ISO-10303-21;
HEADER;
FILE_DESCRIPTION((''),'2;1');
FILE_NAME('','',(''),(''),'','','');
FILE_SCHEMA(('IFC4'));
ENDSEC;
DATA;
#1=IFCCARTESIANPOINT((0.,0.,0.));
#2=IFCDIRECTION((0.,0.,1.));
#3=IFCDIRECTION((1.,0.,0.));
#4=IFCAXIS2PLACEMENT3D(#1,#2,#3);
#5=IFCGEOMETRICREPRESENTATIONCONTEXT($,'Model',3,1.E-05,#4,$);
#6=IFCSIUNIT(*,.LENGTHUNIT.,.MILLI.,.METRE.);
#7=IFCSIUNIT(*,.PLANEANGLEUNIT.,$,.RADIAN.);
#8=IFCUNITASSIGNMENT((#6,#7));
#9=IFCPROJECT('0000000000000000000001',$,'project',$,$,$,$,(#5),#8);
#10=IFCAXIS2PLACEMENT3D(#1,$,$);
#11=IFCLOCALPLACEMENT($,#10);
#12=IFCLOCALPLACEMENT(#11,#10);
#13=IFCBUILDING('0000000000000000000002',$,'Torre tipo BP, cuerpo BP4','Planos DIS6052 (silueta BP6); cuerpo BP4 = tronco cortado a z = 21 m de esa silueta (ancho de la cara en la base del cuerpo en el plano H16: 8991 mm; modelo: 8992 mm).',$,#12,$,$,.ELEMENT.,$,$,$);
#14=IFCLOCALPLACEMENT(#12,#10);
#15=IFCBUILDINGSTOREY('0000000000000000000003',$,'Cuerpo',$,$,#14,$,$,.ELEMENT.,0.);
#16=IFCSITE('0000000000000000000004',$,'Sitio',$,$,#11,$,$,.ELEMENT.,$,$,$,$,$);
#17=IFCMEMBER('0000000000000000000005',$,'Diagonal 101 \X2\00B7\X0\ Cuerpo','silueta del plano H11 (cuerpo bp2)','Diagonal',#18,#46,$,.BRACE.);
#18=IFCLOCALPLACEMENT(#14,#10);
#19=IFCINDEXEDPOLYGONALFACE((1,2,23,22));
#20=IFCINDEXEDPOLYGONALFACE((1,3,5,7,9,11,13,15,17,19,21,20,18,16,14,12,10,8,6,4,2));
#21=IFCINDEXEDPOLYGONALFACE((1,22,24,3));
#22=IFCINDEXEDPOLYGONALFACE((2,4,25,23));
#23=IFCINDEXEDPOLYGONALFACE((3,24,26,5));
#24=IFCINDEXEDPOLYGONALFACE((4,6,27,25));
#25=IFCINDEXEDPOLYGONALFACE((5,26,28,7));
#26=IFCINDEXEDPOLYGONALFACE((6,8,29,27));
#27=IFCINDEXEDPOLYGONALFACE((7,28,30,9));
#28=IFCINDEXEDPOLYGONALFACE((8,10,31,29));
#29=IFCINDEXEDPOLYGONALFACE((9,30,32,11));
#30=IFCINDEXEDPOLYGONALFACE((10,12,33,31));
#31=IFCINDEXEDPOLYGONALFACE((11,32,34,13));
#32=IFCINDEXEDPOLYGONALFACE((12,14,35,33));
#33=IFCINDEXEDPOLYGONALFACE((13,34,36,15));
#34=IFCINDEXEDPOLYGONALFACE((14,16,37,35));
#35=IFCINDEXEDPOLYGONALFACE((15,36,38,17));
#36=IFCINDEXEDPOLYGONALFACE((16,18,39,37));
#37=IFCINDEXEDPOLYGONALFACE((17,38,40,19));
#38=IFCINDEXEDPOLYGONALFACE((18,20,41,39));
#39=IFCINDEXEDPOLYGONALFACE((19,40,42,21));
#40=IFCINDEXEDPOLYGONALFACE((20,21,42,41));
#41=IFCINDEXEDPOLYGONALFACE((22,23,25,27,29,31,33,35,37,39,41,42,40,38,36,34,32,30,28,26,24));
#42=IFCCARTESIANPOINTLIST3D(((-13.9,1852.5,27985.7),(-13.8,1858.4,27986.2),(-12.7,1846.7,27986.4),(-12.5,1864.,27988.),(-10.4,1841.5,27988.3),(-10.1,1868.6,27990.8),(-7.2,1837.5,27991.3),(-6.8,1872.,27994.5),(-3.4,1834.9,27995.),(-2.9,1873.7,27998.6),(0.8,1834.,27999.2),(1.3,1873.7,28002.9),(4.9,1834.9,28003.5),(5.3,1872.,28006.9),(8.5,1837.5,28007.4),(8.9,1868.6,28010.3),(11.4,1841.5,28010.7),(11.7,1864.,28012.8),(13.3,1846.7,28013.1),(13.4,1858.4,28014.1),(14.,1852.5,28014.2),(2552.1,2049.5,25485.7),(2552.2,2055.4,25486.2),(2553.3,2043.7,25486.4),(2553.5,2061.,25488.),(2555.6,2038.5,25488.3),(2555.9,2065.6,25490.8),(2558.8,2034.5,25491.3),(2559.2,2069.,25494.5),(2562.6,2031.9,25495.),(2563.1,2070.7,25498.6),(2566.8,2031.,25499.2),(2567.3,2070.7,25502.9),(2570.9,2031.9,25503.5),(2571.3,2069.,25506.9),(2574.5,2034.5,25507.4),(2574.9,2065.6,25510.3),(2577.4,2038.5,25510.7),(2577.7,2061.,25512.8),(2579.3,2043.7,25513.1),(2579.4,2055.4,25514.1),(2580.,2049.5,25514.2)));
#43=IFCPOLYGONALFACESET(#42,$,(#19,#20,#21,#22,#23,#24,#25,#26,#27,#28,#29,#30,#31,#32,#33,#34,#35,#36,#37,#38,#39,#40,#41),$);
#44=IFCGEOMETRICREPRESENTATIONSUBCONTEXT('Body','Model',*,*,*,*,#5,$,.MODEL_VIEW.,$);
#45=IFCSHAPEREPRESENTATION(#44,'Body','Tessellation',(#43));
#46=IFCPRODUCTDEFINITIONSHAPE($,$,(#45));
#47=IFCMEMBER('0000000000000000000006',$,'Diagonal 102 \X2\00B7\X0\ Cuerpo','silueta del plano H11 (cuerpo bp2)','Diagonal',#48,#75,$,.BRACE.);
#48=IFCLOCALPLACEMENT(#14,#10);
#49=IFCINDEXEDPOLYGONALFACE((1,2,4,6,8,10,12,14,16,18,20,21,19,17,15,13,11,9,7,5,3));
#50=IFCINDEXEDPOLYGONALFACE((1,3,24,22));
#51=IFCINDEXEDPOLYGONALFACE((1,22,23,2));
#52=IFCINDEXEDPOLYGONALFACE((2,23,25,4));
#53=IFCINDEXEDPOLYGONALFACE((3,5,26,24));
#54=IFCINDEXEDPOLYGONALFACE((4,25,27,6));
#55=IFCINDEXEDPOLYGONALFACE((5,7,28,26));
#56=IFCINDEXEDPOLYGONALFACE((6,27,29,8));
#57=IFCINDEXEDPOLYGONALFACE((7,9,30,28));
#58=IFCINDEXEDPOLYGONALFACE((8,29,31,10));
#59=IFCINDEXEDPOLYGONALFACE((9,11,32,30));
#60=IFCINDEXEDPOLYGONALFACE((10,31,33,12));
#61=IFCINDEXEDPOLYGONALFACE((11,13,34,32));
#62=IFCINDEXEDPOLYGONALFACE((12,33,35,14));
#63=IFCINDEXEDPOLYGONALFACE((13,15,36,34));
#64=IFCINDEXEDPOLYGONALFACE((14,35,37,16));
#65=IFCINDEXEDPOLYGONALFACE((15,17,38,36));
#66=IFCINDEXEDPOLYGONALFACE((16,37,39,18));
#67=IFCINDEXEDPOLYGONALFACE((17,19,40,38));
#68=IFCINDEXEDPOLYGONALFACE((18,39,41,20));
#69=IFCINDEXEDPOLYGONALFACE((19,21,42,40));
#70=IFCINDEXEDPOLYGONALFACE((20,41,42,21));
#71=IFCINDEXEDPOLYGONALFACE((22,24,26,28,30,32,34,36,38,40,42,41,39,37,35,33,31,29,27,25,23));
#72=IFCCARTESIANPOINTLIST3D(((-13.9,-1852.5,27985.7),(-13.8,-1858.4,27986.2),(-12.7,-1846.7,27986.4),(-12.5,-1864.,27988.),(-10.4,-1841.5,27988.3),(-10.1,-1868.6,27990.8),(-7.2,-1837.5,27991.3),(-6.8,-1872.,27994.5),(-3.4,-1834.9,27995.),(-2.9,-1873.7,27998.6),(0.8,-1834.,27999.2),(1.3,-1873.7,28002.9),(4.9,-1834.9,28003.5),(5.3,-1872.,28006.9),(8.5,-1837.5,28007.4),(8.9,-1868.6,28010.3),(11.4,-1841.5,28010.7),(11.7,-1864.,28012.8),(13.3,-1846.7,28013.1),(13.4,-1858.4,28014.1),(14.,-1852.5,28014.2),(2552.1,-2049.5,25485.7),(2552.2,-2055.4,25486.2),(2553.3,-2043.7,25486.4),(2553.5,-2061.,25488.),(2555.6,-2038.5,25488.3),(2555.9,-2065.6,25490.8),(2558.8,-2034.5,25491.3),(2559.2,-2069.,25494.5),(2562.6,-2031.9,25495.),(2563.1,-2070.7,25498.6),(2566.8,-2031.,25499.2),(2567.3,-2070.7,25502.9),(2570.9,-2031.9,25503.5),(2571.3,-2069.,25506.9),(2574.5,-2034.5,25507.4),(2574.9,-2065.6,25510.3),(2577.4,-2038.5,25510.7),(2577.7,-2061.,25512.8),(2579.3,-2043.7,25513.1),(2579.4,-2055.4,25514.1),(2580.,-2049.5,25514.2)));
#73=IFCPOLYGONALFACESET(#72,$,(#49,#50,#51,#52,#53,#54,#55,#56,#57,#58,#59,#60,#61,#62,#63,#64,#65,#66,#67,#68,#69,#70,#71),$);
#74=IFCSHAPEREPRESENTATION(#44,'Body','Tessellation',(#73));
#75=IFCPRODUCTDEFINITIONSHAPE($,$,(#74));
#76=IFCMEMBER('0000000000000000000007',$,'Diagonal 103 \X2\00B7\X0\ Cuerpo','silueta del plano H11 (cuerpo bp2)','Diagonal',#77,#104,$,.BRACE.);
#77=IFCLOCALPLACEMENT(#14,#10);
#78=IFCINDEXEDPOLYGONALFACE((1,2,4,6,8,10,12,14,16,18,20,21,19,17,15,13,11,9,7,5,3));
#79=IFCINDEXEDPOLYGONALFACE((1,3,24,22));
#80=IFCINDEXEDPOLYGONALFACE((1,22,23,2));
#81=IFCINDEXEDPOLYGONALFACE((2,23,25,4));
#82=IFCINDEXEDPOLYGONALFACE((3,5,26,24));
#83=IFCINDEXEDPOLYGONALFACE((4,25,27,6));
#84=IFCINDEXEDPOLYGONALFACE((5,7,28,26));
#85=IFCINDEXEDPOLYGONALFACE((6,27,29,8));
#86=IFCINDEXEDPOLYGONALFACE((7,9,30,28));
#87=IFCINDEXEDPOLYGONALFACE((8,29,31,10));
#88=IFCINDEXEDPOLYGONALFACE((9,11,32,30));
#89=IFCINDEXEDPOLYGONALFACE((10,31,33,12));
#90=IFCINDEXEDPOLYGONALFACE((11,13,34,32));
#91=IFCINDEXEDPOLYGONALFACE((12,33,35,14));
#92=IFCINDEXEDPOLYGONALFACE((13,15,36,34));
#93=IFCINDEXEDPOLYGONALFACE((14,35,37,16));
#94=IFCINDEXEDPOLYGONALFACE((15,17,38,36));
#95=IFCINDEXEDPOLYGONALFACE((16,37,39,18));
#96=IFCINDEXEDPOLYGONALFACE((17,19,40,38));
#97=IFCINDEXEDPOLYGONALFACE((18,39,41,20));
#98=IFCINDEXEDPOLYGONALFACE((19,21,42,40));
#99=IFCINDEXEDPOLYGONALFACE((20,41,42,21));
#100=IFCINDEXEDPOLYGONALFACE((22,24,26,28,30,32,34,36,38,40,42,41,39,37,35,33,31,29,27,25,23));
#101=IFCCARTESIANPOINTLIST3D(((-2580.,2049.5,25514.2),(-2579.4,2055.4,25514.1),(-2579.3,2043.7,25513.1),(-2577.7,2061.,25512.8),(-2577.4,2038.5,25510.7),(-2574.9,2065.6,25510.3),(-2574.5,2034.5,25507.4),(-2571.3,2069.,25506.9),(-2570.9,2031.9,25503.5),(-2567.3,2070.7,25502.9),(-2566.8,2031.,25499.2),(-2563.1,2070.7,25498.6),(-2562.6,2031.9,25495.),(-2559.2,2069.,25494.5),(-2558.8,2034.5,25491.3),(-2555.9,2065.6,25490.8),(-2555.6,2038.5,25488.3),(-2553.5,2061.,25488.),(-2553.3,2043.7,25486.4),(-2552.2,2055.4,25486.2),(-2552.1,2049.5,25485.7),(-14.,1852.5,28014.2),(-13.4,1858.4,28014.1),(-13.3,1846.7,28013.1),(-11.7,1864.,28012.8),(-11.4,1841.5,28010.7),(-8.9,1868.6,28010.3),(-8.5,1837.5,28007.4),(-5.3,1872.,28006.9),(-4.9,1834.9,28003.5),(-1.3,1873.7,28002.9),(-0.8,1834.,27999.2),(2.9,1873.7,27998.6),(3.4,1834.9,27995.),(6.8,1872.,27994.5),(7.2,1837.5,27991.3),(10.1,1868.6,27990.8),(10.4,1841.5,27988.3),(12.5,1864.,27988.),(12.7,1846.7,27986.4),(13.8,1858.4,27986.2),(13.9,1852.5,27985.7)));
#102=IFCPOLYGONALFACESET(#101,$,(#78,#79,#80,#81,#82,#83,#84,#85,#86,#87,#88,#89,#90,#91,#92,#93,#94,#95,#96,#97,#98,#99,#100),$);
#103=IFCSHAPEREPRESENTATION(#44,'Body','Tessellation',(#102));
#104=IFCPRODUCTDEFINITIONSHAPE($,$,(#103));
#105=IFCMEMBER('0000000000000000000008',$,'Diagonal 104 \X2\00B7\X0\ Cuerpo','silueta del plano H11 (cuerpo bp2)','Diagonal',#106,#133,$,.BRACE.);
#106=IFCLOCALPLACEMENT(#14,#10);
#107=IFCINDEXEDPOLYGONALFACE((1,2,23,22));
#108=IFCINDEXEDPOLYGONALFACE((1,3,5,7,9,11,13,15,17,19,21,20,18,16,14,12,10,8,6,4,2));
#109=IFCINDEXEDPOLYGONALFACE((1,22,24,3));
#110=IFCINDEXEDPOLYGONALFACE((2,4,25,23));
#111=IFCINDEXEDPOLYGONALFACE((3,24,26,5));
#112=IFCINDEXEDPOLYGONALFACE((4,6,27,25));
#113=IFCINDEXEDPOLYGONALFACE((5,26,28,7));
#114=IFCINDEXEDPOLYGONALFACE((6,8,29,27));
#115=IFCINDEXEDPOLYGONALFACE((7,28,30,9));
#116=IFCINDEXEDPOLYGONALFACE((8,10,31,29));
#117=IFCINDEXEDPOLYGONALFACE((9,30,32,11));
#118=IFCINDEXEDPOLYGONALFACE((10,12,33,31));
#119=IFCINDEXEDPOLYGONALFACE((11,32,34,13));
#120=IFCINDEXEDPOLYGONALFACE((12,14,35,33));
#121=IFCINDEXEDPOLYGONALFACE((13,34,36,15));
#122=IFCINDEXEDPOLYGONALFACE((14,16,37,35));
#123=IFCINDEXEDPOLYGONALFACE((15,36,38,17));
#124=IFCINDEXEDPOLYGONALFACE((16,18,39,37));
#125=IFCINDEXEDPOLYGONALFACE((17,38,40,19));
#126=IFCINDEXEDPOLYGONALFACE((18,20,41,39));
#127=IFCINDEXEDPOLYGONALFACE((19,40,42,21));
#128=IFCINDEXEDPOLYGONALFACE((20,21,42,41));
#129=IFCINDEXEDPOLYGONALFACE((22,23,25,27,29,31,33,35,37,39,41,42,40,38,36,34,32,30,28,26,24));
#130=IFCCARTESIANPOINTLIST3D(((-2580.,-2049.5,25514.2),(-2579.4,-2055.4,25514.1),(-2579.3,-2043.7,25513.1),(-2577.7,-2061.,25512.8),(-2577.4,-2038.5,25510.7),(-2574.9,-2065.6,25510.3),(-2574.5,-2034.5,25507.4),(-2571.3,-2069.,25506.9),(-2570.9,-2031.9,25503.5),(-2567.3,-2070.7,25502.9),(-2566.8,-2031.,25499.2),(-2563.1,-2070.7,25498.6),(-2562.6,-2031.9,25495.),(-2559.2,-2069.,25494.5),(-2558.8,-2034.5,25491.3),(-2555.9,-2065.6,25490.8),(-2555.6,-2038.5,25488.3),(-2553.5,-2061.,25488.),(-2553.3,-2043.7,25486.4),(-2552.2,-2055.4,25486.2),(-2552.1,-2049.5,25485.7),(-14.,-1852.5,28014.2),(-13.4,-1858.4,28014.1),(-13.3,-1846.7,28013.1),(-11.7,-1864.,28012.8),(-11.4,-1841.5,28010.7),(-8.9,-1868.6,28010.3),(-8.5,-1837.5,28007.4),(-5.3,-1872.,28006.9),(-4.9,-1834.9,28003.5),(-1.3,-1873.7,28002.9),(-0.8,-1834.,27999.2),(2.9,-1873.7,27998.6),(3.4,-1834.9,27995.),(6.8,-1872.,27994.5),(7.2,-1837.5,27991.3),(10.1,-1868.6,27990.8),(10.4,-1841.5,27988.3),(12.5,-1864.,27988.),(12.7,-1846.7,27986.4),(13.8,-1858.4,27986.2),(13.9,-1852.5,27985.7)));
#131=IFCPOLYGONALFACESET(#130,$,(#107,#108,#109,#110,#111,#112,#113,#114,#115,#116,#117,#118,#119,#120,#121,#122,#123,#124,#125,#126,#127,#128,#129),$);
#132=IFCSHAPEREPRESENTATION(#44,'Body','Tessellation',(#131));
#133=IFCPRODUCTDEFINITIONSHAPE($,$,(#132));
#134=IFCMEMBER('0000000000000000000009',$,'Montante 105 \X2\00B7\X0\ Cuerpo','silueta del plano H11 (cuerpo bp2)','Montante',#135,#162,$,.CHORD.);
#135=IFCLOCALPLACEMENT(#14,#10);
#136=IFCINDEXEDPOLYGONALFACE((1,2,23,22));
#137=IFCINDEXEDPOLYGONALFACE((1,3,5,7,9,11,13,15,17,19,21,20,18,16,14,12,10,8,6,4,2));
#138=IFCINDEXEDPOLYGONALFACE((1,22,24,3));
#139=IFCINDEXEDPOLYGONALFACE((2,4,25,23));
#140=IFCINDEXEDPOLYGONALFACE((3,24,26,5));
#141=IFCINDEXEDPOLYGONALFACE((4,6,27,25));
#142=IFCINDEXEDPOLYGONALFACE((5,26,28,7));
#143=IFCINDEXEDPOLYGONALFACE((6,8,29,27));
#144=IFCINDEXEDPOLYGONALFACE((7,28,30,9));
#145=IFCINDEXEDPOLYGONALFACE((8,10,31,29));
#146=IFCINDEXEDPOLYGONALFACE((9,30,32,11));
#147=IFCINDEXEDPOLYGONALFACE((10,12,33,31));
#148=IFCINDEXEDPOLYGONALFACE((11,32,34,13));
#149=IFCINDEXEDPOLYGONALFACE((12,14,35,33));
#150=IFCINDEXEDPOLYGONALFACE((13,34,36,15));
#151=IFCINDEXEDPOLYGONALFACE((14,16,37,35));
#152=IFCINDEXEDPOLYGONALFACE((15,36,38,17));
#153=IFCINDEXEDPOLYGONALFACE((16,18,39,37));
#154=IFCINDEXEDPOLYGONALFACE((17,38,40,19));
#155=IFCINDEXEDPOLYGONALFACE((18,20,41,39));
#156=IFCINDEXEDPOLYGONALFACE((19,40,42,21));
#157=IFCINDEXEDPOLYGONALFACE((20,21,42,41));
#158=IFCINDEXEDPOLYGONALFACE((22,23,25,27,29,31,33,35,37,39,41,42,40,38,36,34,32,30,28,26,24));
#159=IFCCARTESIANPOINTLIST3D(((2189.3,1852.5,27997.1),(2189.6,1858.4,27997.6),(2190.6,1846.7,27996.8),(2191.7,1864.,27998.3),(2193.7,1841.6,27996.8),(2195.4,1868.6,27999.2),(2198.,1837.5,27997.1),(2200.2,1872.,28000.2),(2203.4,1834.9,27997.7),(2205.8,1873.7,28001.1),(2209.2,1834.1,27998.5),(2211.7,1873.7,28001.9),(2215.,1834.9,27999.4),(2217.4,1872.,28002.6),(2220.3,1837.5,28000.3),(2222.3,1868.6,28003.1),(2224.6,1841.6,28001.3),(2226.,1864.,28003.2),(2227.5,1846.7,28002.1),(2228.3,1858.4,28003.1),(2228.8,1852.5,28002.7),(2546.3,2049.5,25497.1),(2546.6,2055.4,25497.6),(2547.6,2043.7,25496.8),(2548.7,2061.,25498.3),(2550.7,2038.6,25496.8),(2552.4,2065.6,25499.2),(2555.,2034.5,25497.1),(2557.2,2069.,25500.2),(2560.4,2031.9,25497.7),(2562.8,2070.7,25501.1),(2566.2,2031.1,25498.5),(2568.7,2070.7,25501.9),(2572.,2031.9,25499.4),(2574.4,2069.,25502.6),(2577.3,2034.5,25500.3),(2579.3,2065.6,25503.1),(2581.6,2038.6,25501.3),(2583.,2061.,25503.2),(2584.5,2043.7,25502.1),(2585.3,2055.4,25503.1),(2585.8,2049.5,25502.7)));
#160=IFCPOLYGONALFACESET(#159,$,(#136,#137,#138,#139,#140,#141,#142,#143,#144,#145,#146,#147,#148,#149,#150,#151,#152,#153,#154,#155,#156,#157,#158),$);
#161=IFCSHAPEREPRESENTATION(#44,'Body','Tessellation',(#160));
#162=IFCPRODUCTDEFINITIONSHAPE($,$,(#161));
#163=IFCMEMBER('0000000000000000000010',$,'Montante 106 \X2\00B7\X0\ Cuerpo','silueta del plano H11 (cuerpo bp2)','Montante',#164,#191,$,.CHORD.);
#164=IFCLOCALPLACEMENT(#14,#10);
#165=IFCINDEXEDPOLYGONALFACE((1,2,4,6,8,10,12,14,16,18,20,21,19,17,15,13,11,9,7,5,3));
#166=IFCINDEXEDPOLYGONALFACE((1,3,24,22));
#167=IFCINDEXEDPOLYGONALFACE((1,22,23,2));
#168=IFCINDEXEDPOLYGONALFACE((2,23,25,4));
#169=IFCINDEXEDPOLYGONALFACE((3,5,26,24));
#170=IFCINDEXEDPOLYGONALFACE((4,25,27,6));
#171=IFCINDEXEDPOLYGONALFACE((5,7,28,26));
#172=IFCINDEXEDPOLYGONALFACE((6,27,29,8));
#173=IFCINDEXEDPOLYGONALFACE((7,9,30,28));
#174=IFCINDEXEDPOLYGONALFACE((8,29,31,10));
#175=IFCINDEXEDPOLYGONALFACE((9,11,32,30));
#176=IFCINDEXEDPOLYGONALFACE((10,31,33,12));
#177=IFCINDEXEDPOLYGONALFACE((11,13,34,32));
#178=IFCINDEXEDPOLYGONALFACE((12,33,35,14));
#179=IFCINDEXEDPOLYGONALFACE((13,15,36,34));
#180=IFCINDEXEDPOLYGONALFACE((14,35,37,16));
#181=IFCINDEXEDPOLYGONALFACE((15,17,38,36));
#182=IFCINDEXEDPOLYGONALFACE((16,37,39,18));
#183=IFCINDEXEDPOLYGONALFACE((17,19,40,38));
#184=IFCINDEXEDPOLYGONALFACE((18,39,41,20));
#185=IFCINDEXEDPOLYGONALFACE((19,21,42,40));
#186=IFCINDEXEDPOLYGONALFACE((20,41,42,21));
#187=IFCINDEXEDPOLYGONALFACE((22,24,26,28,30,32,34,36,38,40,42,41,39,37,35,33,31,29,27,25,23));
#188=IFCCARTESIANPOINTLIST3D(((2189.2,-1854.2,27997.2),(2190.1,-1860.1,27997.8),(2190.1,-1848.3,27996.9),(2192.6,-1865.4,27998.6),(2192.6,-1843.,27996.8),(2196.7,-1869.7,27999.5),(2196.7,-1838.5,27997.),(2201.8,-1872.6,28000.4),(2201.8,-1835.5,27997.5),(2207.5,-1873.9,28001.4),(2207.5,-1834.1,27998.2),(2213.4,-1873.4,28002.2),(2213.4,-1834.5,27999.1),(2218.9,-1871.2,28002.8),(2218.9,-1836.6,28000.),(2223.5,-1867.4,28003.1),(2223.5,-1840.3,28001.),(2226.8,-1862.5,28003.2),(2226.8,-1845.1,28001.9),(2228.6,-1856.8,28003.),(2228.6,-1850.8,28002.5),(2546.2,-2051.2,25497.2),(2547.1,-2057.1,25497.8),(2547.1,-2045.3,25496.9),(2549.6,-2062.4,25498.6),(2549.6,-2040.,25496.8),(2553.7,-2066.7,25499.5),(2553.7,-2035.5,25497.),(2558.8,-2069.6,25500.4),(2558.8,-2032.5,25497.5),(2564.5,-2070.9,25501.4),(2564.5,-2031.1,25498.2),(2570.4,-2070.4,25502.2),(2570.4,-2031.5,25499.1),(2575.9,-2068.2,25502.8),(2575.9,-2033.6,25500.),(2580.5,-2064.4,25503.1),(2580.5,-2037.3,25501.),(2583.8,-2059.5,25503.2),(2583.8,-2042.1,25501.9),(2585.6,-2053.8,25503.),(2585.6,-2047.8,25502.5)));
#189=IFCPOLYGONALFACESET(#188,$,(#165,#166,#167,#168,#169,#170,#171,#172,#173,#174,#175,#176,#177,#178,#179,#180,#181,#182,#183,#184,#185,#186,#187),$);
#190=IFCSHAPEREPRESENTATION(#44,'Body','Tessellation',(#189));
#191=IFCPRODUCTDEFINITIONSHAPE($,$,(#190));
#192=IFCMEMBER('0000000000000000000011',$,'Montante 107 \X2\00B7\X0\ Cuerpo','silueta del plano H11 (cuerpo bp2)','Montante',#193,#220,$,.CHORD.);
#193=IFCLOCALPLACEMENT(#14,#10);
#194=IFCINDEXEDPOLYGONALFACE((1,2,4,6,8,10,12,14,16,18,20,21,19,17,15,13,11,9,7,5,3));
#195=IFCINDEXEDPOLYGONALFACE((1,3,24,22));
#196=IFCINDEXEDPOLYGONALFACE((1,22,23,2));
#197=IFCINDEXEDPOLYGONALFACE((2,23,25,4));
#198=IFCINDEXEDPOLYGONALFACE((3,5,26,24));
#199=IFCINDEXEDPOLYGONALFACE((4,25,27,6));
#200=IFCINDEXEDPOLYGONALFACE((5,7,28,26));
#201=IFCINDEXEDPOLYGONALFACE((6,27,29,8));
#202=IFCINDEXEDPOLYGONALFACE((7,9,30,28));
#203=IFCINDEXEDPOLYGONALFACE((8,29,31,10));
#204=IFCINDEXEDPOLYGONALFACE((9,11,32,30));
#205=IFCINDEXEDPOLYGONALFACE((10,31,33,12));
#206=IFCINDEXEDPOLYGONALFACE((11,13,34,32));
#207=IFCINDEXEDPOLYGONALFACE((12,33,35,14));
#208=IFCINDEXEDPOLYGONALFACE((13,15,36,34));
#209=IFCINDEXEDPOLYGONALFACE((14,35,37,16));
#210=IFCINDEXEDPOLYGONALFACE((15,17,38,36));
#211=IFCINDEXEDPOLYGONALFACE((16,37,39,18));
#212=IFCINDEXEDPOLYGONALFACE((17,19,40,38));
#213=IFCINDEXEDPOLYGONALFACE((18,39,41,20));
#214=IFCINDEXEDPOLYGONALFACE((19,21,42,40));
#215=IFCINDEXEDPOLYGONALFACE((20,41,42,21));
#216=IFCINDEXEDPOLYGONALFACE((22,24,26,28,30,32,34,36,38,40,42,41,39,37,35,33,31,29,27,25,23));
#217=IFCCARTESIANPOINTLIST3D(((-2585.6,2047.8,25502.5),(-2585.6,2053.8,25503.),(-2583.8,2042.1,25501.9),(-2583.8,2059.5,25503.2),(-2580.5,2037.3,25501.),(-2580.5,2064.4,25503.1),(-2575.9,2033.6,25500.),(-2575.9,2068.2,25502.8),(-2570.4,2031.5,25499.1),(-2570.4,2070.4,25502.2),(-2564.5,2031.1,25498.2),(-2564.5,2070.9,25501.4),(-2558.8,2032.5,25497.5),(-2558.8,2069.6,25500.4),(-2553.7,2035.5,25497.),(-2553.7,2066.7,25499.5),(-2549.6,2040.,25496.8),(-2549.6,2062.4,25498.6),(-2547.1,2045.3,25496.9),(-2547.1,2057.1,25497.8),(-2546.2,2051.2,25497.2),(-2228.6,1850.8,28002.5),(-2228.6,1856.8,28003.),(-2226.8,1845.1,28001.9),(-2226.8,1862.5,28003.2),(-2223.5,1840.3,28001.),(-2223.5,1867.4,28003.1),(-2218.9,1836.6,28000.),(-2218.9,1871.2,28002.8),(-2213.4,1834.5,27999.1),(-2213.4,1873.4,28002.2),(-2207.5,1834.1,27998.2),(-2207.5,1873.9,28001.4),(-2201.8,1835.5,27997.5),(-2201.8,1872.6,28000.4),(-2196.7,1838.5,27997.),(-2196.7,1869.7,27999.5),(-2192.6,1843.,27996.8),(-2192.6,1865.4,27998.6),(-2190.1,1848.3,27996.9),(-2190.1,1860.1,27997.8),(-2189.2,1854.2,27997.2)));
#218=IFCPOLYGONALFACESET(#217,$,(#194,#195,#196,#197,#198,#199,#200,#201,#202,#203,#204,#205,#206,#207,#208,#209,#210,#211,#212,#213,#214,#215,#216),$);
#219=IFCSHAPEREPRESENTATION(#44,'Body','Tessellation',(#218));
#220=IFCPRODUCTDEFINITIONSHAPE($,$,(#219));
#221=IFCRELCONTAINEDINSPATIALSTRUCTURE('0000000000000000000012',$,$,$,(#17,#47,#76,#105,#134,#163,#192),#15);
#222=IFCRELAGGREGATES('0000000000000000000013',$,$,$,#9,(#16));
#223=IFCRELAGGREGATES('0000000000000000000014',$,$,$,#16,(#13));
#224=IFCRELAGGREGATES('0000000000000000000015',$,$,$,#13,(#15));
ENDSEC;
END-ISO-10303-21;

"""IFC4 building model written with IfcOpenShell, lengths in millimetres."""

from ifc_helpers import new_model, si_unit, frame, origin, origin_with_axes, place, context, subcontext, project, spatial, circle, extrude, element, save


model = new_model("IFC4")

# Units and contexts
model_context = context("Model", 3, precision=1e-05, world=origin_with_axes())
body_context = subcontext(model_context, "Body", "Model", "MODEL_VIEW")
ifc_project = project(units=[si_unit("LENGTHUNIT", "METRE", prefix="MILLI"), si_unit("PLANEANGLEUNIT", "RADIAN")], contexts=[model_context])

# Site, building, storey
site_placement = place(None, origin())
site = spatial("IfcSite", under=ifc_project, at=site_placement, Name="Sitio", CompositionType="ELEMENT")
building_placement = place(site_placement, origin())
building = spatial("IfcBuilding", under=site, at=building_placement, Name="Torre tipo BP, cuerpo BP4", Description="Planos DIS6052 (silueta BP6); cuerpo BP4 = tronco cortado a z = 21 m de esa silueta (ancho de la cara en la base del cuerpo en el plano H16: 8991 mm; modelo: 8992 mm).", CompositionType="ELEMENT")
storey_placement = place(building_placement, origin())
storey = spatial("IfcBuildingStorey", under=building, at=storey_placement, Name="Cuerpo", CompositionType="ELEMENT", Elevation=0.0)

# Members
for number, where, z_axis, x_axis, name in (
    (1, (0.0, 1854.0, 28000.0), (0.715178, 0.054906, -0.696783), (0.039327, -0.998492, -0.038316), "Diagonal 101 · Cuerpo"),
    (2, (0.0, -1854.0, 28000.0), (0.715178, -0.054906, -0.696783), (0.039327, 0.998492, -0.038316), "Diagonal 102 · Cuerpo"),
    (3, (0.0, 1854.0, 28000.0), (-0.715178, 0.054906, -0.696783), (-0.039327, -0.998492, -0.038316), "Diagonal 103 · Cuerpo"),
    (4, (0.0, -1854.0, 28000.0), (-0.715178, -0.054906, -0.696783), (-0.039327, 0.998492, -0.038316), "Diagonal 104 · Cuerpo"),
):
    element("IfcMember", number, at=place(storey_placement, frame(where, z_axis=z_axis, x_axis=x_axis)), inside=storey, Name=name, Description="silueta del plano H11 (cuerpo bp2)", ObjectType="Diagonal", PredefinedType="BRACE", context=body_context, shape_type="SweptSolid", body=[
        extrude(circle(Radius=20.0), None, (0.0, 0.0, 1.0), 3587.9),
    ])
for number, where, z_axis, x_axis, name in (
    (5, (2209.0, 1854.0, 28000.0), (0.140938, 0.077772, -0.986959), (0.010994, -0.996971, -0.076991), "Montante 105 · Cuerpo"),
    (6, (2209.0, -1854.0, 28000.0), (0.140938, -0.077772, -0.986959), (-0.990018, -0.011072, -0.140502), "Montante 106 · Cuerpo"),
    (7, (-2209.0, 1854.0, 28000.0), (-0.140938, 0.077772, -0.986959), (0.990018, 0.011072, -0.140502), "Montante 107 · Cuerpo"),
):
    element("IfcMember", number, at=place(storey_placement, frame(where, z_axis=z_axis, x_axis=x_axis)), inside=storey, Name=name, Description="silueta del plano H11 (cuerpo bp2)", ObjectType="Montante", PredefinedType="CHORD", context=body_context, shape_type="SweptSolid", body=[
        extrude(circle(Radius=20.0), None, (0.0, 0.0, 1.0), 2533.0),
    ])

save(model, "model.ifc")
